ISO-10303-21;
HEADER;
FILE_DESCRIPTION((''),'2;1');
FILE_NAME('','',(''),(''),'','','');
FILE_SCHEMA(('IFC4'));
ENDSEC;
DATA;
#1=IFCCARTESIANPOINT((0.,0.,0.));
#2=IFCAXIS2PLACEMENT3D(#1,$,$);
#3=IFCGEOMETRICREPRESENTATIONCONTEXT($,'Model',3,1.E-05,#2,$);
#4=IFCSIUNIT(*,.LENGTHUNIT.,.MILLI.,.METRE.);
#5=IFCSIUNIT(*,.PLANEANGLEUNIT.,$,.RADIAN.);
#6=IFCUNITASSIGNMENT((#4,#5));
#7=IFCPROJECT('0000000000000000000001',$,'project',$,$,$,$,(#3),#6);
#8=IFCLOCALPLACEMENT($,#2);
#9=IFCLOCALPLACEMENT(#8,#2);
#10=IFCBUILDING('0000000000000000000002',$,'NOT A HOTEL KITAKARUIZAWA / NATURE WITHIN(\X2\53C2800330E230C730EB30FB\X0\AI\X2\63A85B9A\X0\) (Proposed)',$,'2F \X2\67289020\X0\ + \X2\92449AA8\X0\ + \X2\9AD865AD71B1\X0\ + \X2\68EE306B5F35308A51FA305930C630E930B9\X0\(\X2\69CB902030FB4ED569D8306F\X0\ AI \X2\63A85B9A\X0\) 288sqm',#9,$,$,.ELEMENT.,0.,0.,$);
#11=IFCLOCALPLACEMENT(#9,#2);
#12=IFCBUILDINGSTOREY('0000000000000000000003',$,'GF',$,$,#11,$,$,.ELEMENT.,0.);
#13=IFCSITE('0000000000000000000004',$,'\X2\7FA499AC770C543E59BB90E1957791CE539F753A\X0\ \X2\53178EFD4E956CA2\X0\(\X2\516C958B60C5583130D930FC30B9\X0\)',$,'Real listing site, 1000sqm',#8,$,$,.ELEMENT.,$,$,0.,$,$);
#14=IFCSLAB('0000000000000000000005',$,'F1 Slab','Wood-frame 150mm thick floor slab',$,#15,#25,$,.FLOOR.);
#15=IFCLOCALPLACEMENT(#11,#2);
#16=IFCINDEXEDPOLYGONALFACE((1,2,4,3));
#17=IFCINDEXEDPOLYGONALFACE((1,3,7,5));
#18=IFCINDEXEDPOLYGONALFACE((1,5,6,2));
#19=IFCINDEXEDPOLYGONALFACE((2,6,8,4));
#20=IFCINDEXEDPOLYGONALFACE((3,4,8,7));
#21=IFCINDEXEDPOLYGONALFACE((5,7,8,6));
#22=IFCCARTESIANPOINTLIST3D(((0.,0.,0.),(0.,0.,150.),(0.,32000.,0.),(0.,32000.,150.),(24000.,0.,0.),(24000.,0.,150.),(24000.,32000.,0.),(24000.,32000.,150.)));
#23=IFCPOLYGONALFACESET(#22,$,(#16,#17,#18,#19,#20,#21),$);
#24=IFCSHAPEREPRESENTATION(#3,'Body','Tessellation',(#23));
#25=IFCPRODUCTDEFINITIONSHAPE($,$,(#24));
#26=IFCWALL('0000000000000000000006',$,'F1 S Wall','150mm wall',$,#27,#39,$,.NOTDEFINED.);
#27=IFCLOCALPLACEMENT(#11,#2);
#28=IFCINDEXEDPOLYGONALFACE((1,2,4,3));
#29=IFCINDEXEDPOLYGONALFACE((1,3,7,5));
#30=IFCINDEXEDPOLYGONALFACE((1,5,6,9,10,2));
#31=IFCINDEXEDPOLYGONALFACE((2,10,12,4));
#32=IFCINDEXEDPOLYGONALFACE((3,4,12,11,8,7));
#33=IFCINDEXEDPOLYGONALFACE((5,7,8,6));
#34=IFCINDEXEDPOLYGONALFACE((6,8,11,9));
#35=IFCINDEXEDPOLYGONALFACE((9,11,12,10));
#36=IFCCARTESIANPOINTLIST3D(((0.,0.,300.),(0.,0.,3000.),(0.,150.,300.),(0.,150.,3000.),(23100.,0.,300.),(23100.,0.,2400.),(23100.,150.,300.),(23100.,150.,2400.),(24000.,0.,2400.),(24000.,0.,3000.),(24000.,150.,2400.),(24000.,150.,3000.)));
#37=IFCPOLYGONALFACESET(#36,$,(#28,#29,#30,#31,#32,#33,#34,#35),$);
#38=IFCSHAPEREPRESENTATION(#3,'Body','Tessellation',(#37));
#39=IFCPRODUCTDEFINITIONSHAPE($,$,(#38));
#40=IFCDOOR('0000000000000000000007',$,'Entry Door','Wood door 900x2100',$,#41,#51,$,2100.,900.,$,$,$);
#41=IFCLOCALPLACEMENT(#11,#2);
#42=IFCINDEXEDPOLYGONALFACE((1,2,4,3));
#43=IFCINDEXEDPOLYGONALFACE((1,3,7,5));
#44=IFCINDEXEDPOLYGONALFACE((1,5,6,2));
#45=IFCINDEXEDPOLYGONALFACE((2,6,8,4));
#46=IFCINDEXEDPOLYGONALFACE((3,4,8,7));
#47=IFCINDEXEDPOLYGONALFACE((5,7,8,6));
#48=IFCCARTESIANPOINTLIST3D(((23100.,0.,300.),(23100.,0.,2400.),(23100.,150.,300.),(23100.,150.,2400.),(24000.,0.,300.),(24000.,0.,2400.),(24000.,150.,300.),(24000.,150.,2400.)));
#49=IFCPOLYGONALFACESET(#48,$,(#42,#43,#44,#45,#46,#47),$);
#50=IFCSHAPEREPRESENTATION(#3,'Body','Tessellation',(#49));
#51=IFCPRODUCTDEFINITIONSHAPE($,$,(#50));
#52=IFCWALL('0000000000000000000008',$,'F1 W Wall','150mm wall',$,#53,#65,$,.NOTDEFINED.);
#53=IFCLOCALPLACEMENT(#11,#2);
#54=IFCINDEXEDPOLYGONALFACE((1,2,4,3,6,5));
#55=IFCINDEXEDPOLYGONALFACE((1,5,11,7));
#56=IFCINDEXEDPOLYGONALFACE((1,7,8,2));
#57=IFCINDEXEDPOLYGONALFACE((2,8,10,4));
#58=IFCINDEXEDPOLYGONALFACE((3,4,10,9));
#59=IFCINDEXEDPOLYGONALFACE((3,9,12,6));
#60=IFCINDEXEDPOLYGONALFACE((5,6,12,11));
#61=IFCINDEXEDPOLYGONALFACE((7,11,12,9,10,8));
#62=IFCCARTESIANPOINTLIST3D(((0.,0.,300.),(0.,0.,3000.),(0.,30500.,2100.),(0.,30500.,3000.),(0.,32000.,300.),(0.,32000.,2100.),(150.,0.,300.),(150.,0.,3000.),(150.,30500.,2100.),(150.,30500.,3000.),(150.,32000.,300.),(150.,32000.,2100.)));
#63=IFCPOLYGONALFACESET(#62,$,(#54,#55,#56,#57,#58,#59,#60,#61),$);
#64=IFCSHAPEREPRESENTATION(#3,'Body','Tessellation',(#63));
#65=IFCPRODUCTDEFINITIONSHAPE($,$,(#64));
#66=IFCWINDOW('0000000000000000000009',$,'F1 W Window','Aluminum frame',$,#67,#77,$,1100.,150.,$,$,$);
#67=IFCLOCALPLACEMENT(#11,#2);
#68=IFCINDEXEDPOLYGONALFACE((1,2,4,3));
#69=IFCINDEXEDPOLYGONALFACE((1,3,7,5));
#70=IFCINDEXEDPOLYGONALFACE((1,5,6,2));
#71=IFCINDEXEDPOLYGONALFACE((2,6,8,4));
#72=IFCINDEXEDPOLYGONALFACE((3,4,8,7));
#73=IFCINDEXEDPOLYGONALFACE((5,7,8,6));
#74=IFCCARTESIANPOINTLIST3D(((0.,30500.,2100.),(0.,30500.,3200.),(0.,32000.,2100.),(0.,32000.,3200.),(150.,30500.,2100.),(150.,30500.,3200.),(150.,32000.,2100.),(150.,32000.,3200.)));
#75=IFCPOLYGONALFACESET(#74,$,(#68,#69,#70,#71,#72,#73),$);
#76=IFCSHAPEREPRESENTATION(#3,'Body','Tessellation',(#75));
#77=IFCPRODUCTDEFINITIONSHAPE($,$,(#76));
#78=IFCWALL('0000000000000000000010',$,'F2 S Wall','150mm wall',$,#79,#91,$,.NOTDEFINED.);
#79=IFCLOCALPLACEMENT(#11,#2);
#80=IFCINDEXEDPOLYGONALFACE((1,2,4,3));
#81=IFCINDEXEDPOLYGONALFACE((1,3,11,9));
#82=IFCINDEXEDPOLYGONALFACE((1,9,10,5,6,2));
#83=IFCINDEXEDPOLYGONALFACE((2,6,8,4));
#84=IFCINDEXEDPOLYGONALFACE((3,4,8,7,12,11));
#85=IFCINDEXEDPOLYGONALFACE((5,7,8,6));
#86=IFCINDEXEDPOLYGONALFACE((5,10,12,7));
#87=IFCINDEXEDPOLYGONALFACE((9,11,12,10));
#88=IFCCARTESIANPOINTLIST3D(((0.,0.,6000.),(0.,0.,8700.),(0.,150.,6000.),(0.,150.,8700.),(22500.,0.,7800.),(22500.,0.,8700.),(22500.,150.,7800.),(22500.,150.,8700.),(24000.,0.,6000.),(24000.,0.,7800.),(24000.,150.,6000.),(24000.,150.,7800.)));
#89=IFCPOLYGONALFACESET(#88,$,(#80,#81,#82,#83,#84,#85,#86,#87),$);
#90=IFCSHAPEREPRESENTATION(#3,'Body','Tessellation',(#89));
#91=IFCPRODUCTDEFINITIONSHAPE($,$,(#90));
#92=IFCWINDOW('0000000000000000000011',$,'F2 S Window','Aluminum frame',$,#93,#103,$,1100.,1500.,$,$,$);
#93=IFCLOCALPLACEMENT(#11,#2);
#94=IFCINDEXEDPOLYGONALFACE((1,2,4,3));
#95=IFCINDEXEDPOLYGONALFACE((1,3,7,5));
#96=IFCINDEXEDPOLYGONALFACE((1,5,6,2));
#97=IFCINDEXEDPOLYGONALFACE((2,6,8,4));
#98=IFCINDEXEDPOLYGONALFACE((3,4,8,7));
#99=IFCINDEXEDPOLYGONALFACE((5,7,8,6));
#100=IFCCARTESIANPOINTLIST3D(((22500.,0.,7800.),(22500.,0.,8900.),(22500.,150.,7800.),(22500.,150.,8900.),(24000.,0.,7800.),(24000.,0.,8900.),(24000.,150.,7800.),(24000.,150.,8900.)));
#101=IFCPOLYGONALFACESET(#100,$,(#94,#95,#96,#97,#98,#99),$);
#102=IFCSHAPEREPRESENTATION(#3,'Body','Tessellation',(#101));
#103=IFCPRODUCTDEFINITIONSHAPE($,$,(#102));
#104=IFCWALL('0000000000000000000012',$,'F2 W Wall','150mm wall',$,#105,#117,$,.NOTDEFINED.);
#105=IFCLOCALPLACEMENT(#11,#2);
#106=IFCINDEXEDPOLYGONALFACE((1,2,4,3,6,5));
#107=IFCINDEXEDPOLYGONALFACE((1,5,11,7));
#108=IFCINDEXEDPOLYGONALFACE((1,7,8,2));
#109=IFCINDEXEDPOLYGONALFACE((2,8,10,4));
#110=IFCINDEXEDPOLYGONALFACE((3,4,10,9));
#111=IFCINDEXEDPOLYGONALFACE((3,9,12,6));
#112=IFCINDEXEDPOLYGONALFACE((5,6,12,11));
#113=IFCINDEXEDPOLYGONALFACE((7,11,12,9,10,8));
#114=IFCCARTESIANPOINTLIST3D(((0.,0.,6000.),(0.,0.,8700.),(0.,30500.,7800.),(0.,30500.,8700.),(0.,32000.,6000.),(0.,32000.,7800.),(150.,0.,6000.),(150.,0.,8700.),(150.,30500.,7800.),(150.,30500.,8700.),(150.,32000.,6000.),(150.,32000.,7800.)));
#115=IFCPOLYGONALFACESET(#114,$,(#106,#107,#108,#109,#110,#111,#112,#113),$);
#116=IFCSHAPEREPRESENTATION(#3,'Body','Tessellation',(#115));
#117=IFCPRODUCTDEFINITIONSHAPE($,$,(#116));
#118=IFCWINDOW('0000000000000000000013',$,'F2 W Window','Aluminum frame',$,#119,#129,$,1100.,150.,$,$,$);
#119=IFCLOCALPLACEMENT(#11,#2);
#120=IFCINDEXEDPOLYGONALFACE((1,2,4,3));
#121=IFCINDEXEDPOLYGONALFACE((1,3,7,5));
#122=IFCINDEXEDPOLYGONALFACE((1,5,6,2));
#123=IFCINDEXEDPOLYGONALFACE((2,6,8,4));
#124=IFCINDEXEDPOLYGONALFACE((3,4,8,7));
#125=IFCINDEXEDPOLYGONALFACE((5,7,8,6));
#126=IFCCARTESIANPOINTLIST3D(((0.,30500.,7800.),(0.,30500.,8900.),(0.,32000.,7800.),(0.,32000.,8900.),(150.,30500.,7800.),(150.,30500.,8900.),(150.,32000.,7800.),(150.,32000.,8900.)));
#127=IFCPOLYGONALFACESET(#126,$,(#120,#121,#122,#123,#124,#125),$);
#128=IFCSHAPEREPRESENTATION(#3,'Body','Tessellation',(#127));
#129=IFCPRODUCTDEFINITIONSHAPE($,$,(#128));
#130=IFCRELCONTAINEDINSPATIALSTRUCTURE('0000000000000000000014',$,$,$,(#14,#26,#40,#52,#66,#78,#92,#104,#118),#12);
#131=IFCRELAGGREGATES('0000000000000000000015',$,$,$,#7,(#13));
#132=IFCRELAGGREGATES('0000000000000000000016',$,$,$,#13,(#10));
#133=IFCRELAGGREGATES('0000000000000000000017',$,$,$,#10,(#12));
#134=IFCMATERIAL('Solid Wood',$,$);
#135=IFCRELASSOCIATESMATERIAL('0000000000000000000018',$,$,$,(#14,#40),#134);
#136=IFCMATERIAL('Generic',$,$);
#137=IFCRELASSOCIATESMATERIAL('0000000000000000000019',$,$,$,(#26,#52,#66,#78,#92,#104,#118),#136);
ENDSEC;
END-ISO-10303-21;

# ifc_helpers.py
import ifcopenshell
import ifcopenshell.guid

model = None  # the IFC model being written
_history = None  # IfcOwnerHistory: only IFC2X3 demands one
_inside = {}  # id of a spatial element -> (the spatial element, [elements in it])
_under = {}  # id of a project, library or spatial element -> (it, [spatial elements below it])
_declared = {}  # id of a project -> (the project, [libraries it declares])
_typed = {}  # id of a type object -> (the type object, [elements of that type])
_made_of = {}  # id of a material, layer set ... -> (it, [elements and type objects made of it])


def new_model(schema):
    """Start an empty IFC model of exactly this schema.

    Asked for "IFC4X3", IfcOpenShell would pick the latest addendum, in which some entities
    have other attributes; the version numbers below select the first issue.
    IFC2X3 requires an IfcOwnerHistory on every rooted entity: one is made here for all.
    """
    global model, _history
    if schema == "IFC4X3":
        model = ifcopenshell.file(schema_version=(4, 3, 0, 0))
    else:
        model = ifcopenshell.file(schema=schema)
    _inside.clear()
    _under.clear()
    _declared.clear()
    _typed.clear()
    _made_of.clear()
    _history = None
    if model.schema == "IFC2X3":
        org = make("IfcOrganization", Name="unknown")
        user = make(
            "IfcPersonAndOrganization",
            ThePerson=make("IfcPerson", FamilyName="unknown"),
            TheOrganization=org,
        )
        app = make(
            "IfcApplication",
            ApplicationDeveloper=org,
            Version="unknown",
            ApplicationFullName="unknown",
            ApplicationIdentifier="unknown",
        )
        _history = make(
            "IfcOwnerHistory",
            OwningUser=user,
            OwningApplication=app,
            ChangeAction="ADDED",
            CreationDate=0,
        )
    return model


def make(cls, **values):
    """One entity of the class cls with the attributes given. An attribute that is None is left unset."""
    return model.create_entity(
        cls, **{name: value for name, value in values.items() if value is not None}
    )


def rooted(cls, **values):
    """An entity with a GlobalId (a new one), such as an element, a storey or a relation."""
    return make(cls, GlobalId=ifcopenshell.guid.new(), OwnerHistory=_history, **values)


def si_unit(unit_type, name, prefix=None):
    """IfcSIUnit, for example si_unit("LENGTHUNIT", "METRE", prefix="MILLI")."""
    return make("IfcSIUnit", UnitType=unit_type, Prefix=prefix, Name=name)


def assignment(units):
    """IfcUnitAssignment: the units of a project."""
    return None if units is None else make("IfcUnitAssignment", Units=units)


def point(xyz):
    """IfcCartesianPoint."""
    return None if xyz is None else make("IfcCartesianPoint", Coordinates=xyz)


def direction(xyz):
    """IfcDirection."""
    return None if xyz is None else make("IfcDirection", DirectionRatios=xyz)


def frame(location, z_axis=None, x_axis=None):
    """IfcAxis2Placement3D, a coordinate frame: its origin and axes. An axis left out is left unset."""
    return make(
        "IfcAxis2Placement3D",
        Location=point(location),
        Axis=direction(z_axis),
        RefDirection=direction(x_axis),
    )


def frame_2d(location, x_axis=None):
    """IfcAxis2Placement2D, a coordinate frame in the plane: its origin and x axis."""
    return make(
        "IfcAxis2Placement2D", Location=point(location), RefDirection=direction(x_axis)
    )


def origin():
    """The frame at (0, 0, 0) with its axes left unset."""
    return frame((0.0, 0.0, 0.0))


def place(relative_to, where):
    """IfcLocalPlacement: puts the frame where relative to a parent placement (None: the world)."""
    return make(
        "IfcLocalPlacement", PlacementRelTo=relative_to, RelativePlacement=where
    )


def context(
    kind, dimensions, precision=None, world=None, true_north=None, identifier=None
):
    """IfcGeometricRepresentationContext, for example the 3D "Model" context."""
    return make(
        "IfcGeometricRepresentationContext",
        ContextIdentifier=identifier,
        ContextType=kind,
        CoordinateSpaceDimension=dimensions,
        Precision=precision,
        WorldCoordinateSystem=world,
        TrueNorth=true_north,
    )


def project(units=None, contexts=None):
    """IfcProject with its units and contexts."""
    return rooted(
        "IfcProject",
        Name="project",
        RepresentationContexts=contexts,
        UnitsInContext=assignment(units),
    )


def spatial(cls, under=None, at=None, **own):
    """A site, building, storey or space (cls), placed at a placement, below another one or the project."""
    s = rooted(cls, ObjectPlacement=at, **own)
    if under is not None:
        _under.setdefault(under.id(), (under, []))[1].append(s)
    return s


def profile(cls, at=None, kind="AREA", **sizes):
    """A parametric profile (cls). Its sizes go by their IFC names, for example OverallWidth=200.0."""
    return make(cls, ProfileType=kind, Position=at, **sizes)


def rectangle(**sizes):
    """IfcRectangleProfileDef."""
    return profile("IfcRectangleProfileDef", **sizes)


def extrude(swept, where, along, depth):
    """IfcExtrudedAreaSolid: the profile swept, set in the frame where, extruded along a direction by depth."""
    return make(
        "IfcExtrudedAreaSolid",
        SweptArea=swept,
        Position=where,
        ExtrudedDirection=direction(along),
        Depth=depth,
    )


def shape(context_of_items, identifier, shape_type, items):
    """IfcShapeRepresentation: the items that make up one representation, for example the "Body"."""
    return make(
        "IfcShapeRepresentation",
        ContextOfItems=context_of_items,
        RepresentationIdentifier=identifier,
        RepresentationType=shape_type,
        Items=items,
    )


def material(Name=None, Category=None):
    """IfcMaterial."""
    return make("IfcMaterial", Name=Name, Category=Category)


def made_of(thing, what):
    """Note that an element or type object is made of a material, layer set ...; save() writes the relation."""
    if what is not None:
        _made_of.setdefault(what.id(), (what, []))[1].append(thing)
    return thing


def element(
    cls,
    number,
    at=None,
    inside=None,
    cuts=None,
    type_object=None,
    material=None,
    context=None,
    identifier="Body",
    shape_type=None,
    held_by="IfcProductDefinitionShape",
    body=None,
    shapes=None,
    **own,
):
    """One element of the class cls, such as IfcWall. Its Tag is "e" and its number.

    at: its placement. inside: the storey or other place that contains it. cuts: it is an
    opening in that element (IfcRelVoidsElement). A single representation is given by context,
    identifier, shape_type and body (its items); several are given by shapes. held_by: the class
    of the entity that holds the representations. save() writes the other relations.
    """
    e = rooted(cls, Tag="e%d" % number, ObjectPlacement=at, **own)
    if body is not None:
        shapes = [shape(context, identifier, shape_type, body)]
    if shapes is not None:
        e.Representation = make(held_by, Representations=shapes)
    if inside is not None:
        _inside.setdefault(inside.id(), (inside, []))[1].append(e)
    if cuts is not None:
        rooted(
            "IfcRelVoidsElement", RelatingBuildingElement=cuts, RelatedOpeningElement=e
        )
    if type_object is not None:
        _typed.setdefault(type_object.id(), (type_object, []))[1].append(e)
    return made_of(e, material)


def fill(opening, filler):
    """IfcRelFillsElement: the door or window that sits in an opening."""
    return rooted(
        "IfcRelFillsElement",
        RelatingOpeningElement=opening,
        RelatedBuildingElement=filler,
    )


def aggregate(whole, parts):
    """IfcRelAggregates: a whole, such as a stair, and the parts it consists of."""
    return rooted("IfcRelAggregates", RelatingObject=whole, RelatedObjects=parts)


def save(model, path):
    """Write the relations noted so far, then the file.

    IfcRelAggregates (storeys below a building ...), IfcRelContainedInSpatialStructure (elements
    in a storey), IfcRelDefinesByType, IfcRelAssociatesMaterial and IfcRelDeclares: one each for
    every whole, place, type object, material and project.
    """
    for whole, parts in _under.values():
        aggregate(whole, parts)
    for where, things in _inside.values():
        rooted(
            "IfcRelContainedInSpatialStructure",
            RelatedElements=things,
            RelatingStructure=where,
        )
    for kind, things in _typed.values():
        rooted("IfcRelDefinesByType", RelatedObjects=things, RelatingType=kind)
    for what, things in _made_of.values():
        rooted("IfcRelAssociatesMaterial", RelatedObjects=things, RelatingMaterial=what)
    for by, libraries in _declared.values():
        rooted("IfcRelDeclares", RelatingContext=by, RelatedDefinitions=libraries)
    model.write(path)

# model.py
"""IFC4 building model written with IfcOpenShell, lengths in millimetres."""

from ifc_helpers import new_model, si_unit, frame, frame_2d, origin, place, context, project, spatial, rectangle, extrude, material, element, fill, save


model = new_model("IFC4")

# Units and contexts
model_context = context("Model", 3, precision=1e-05, world=origin())
ifc_project = project(units=[si_unit("LENGTHUNIT", "METRE", prefix="MILLI"), si_unit("PLANEANGLEUNIT", "RADIAN")], contexts=[model_context])

# Site, building, storey
site_placement = place(None, origin())
site = spatial("IfcSite", under=ifc_project, at=site_placement, Name="群馬県吾妻郡長野原町 北軽井沢(公開情報ベース)", ObjectType="Real listing site, 1000sqm", CompositionType="ELEMENT", RefElevation=0.0)
building_placement = place(site_placement, origin())
building = spatial("IfcBuilding", under=site, at=building_placement, Name="NOT A HOTEL KITAKARUIZAWA / NATURE WITHIN(参考モデル・AI推定) (Proposed)", ObjectType="2F 木造 + 鉄骨 + 高断熱 + 森に張り出すテラス(構造・仕様は AI 推定) 288sqm", CompositionType="ELEMENT", ElevationOfRefHeight=0.0, ElevationOfTerrain=0.0)
storey_placement = place(building_placement, origin())
storey = spatial("IfcBuildingStorey", under=building, at=storey_placement, Name="GF", CompositionType="ELEMENT", Elevation=0.0)

# Slab
ifc_material_1 = material(Name="Solid Wood")
slab_1_placement = place(storey_placement, origin())
element("IfcSlab", 1, at=slab_1_placement, inside=storey, material=ifc_material_1, Name="F1 Slab", Description="Wood-frame 150mm thick floor slab", PredefinedType="FLOOR", context=model_context, shape_type="SweptSolid", body=[
    extrude(rectangle(XDim=24000.0, YDim=32000.0, at=frame_2d((12000.0, 16000.0))), origin(), (0.0, 0.0, 1.0), 150.0),
])

# Shared definitions
ifc_material_2 = material(Name="Generic")

# Wall, opening, door
wall_1_placement = place(storey_placement, frame((0.0, 0.0, 150.0)))
wall_1 = element("IfcWall", 2, at=wall_1_placement, inside=storey, material=ifc_material_2, Name="F1 S Wall", Description="150mm wall", PredefinedType="NOTDEFINED", context=model_context, shape_type="SweptSolid", body=[
    extrude(rectangle(XDim=24000.0, YDim=150.0, at=frame_2d((12000.0, 75.0))), frame((0.0, 0.0, 150.0)), (0.0, 0.0, 1.0), 2700.0),
])
opening_1_placement = place(storey_placement, frame((11550.0, 0.0, 150.0)))
opening_1 = element("IfcOpeningElement", 3, at=opening_1_placement, cuts=wall_1, PredefinedType="NOTDEFINED", context=model_context, shape_type="SweptSolid", body=[
    extrude(rectangle(XDim=900.0, YDim=150.0, at=frame_2d((450.0, 75.0))), frame((11550.0, 0.0, 150.0)), (0.0, 0.0, 1.0), 2100.0),
])
door_placement = place(storey_placement, frame((11550.0, 0.0, 150.0)))
door = element("IfcDoor", 4, at=door_placement, inside=storey, material=ifc_material_1, Name="Entry Door", Description="Wood door 900x2100", OverallHeight=2100.0, OverallWidth=900.0, context=model_context, shape_type="SweptSolid", body=[
    extrude(rectangle(XDim=900.0, YDim=150.0, at=frame_2d((450.0, 75.0))), frame((11550.0, 0.0, 150.0)), (0.0, 0.0, 1.0), 2100.0),
])
fill(opening_1, door)

# Walls, openings, windows
wall_2_placement = place(storey_placement, frame((0.0, 0.0, 150.0)))
wall_2 = element("IfcWall", 5, at=wall_2_placement, inside=storey, material=ifc_material_2, Name="F1 W Wall", Description="150mm wall", PredefinedType="NOTDEFINED", context=model_context, shape_type="SweptSolid", body=[
    extrude(rectangle(XDim=150.0, YDim=32000.0, at=frame_2d((75.0, 16000.0))), frame((0.0, 0.0, 150.0)), (0.0, 0.0, 1.0), 2700.0),
])
opening_2_placement = place(storey_placement, frame((0.0, 15250.0, 1050.0)))
opening_2 = element("IfcOpeningElement", 6, at=opening_2_placement, cuts=wall_2, PredefinedType="NOTDEFINED", context=model_context, shape_type="SweptSolid", body=[
    extrude(rectangle(XDim=150.0, YDim=1500.0, at=frame_2d((75.0, 750.0))), frame((0.0, 15250.0, 1050.0)), (0.0, 0.0, 1.0), 1100.0),
])
window_1_placement = place(storey_placement, frame((0.0, 15250.0, 1050.0)))
window_1 = element("IfcWindow", 7, at=window_1_placement, inside=storey, material=ifc_material_2, Name="F1 W Window", Description="Aluminum frame", OverallHeight=1100.0, OverallWidth=150.0, context=model_context, shape_type="SweptSolid", body=[
    extrude(rectangle(XDim=150.0, YDim=1500.0, at=frame_2d((75.0, 750.0))), frame((0.0, 15250.0, 1050.0)), (0.0, 0.0, 1.0), 1100.0),
])
fill(opening_2, window_1)
wall_3_placement = place(storey_placement, frame((0.0, 0.0, 3000.0)))
wall_3 = element("IfcWall", 8, at=wall_3_placement, inside=storey, material=ifc_material_2, Name="F2 S Wall", Description="150mm wall", PredefinedType="NOTDEFINED", context=model_context, shape_type="SweptSolid", body=[
    extrude(rectangle(XDim=24000.0, YDim=150.0, at=frame_2d((12000.0, 75.0))), frame((0.0, 0.0, 3000.0)), (0.0, 0.0, 1.0), 2700.0),
])
opening_3_placement = place(storey_placement, frame((11250.0, 0.0, 3900.0)))
opening_3 = element("IfcOpeningElement", 9, at=opening_3_placement, cuts=wall_3, PredefinedType="NOTDEFINED", context=model_context, shape_type="SweptSolid", body=[
    extrude(rectangle(XDim=1500.0, YDim=150.0, at=frame_2d((750.0, 75.0))), frame((11250.0, 0.0, 3900.0)), (0.0, 0.0, 1.0), 1100.0),
])
window_2_placement = place(storey_placement, frame((11250.0, 0.0, 3900.0)))
window_2 = element("IfcWindow", 10, at=window_2_placement, inside=storey, material=ifc_material_2, Name="F2 S Window", Description="Aluminum frame", OverallHeight=1100.0, OverallWidth=1500.0, context=model_context, shape_type="SweptSolid", body=[
    extrude(rectangle(XDim=1500.0, YDim=150.0, at=frame_2d((750.0, 75.0))), frame((11250.0, 0.0, 3900.0)), (0.0, 0.0, 1.0), 1100.0),
])
fill(opening_3, window_2)
wall_4_placement = place(storey_placement, frame((0.0, 0.0, 3000.0)))
wall_4 = element("IfcWall", 11, at=wall_4_placement, inside=storey, material=ifc_material_2, Name="F2 W Wall", Description="150mm wall", PredefinedType="NOTDEFINED", context=model_context, shape_type="SweptSolid", body=[
    extrude(rectangle(XDim=150.0, YDim=32000.0, at=frame_2d((75.0, 16000.0))), frame((0.0, 0.0, 3000.0)), (0.0, 0.0, 1.0), 2700.0),
])
opening_4_placement = place(storey_placement, frame((0.0, 15250.0, 3900.0)))
opening_4 = element("IfcOpeningElement", 12, at=opening_4_placement, cuts=wall_4, PredefinedType="NOTDEFINED", context=model_context, shape_type="SweptSolid", body=[
    extrude(rectangle(XDim=150.0, YDim=1500.0, at=frame_2d((75.0, 750.0))), frame((0.0, 15250.0, 3900.0)), (0.0, 0.0, 1.0), 1100.0),
])
window_3_placement = place(storey_placement, frame((0.0, 15250.0, 3900.0)))
window_3 = element("IfcWindow", 13, at=window_3_placement, inside=storey, material=ifc_material_2, Name="F2 W Window", Description="Aluminum frame", OverallHeight=1100.0, OverallWidth=150.0, context=model_context, shape_type="SweptSolid", body=[
    extrude(rectangle(XDim=150.0, YDim=1500.0, at=frame_2d((75.0, 750.0))), frame((0.0, 15250.0, 3900.0)), (0.0, 0.0, 1.0), 1100.0),
])
fill(opening_4, window_3)

save(model, "model.ifc")
